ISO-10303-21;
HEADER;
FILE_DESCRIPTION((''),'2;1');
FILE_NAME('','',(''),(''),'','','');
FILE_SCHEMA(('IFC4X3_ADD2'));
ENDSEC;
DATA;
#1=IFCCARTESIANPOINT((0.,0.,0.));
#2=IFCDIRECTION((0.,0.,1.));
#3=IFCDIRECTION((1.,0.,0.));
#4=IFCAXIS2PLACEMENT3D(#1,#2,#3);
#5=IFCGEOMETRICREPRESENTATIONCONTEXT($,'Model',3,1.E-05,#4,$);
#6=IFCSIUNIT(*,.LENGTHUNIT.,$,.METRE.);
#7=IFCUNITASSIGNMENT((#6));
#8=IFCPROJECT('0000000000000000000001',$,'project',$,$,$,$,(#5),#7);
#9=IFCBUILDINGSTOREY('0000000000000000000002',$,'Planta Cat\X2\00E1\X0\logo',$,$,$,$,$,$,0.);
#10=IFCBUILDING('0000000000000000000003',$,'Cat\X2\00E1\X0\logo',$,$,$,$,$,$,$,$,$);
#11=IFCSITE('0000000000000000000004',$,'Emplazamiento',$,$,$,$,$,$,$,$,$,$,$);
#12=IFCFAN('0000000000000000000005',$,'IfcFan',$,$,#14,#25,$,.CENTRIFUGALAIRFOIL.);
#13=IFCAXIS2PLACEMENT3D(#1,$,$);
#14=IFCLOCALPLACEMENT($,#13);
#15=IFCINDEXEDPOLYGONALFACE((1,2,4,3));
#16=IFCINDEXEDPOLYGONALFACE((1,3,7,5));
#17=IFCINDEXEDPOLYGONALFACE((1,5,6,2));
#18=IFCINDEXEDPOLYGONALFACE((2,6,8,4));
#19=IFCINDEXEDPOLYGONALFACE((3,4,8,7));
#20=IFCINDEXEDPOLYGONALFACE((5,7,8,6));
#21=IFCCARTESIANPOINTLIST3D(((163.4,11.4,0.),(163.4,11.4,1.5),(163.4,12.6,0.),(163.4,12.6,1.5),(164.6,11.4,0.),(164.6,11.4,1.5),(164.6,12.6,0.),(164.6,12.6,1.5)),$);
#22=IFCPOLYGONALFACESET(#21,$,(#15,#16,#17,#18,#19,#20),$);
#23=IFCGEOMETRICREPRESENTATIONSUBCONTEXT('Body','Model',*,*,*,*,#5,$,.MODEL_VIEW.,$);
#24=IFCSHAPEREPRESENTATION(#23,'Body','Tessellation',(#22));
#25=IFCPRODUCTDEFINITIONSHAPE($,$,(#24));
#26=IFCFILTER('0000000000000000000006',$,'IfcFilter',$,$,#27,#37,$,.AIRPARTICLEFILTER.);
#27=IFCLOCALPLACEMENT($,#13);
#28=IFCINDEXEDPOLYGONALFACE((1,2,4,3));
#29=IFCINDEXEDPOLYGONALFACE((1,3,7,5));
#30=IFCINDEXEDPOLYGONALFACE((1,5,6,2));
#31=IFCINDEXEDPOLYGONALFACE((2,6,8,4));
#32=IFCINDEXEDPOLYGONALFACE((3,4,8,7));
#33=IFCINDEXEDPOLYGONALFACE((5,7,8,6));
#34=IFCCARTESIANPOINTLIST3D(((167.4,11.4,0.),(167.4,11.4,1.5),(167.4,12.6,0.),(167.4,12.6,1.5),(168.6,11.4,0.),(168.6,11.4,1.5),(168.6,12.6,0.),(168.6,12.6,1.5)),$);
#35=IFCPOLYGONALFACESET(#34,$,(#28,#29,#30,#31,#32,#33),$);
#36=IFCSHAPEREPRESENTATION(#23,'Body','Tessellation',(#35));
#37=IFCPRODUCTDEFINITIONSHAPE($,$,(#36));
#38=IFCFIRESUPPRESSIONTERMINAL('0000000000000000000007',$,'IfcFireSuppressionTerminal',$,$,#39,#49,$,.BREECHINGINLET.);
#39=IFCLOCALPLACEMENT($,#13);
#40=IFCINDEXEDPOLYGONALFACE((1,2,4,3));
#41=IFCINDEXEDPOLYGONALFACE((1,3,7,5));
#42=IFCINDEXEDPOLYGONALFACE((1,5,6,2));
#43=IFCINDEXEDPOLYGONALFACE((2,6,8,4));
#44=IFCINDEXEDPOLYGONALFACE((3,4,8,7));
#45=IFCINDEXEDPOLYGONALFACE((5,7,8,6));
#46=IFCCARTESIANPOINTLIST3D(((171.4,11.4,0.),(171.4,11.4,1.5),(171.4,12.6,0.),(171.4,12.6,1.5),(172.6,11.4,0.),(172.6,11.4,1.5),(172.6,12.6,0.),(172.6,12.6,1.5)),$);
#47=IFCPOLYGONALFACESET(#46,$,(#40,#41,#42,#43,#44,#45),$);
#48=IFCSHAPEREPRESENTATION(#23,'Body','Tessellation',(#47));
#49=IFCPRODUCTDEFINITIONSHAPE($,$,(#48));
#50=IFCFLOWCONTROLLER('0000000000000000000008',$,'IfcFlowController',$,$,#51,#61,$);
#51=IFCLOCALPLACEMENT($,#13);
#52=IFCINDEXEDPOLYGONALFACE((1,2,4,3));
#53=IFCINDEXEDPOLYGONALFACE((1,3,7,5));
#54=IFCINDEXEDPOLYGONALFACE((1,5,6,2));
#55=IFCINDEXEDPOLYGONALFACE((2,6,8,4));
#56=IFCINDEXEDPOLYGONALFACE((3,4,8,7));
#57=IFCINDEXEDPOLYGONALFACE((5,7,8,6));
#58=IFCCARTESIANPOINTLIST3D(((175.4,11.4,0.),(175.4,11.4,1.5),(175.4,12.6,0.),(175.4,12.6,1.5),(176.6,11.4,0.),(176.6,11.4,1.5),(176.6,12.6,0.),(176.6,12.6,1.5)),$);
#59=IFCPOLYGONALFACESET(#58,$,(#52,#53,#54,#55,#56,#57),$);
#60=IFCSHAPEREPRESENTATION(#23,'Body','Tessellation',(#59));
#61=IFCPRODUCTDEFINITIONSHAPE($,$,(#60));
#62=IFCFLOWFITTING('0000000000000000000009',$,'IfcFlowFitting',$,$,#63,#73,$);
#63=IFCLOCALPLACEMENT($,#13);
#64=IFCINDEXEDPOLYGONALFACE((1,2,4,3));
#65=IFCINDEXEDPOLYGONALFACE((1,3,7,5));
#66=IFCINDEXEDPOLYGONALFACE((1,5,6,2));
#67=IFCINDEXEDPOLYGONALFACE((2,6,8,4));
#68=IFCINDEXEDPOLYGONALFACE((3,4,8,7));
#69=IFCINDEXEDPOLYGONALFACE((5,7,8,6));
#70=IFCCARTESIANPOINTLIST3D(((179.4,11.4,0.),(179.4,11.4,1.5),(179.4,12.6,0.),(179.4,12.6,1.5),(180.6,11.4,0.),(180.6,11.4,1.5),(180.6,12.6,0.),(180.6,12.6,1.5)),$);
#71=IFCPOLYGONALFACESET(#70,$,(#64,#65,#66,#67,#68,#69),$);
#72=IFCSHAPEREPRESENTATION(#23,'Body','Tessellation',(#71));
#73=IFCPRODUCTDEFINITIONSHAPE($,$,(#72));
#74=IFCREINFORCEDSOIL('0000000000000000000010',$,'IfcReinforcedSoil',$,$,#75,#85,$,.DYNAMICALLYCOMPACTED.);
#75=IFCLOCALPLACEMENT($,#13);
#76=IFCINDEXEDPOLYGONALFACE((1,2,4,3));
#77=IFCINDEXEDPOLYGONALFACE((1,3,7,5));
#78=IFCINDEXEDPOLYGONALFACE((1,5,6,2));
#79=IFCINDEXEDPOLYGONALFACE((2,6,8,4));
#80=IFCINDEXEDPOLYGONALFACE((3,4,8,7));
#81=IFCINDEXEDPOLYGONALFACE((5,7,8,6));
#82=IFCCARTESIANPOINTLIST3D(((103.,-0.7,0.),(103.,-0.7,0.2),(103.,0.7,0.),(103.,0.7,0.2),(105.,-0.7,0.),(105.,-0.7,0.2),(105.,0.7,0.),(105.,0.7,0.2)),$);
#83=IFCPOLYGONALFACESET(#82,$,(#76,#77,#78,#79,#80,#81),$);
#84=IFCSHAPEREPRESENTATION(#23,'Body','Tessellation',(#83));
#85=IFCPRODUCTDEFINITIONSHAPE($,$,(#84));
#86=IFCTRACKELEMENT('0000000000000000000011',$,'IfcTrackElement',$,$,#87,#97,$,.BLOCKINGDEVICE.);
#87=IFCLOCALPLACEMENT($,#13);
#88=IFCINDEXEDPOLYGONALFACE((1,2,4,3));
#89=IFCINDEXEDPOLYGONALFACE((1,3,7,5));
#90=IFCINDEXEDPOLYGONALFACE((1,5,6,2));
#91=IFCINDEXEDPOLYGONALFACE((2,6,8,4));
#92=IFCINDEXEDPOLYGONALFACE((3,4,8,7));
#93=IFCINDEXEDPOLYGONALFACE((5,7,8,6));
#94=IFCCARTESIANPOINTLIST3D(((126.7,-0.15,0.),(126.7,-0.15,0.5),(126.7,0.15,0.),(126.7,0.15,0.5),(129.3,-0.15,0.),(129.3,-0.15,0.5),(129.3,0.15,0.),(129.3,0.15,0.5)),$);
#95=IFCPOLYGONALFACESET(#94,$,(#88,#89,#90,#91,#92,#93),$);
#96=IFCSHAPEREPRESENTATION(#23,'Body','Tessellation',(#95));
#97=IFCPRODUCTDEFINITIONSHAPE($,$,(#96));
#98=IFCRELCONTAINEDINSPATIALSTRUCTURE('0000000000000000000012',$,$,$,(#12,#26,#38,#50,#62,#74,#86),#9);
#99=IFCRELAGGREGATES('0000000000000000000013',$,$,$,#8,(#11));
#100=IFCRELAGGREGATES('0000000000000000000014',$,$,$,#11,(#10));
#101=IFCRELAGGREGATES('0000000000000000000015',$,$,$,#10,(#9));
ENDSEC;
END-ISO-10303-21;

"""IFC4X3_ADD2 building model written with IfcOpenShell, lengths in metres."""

from ifc_helpers import new_model, si_unit, frame, origin, origin_with_axes, origin_2d, place, context, subcontext, project, spatial, rectangle, extrude, element, save


model = new_model("IFC4X3_ADD2")

# Units and contexts
model_context = context("Model", 3, precision=1e-05, world=origin_with_axes())
body_context = subcontext(model_context, "Body", "Model", "MODEL_VIEW")
ifc_project = project(units=[si_unit("LENGTHUNIT", "METRE")], contexts=[model_context])

# Site, building, storey
site = spatial("IfcSite", under=ifc_project, Name="Emplazamiento")
building = spatial("IfcBuilding", under=site, Name="Catálogo")
storey = spatial("IfcBuildingStorey", under=building, Name="Planta Catálogo", Elevation=0.0)

# Fan
fan_placement = place(None, frame((164.0, 12.0, 0.0), z_axis=(0.0, 0.0, 1.0), x_axis=(1.0, 0.0, 0.0)))
element("IfcFan", 1, at=fan_placement, inside=storey, Name="IfcFan", PredefinedType="CENTRIFUGALAIRFOIL", context=body_context, shape_type="SweptSolid", body=[
    extrude(rectangle(XDim=1.2, YDim=1.2, at=origin_2d()), origin(), (0.0, 0.0, 1.0), 1.5),
])

# Filter
ifc_filter_placement = place(None, frame((168.0, 12.0, 0.0), z_axis=(0.0, 0.0, 1.0), x_axis=(1.0, 0.0, 0.0)))
element("IfcFilter", 2, at=ifc_filter_placement, inside=storey, Name="IfcFilter", PredefinedType="AIRPARTICLEFILTER", context=body_context, shape_type="SweptSolid", body=[
    extrude(rectangle(XDim=1.2, YDim=1.2, at=origin_2d()), origin(), (0.0, 0.0, 1.0), 1.5),
])

# Fire suppression terminal
fire_suppression_terminal_placement = place(None, frame((172.0, 12.0, 0.0), z_axis=(0.0, 0.0, 1.0), x_axis=(1.0, 0.0, 0.0)))
element("IfcFireSuppressionTerminal", 3, at=fire_suppression_terminal_placement, inside=storey, Name="IfcFireSuppressionTerminal", PredefinedType="BREECHINGINLET", context=body_context, shape_type="SweptSolid", body=[
    extrude(rectangle(XDim=1.2, YDim=1.2, at=origin_2d()), origin(), (0.0, 0.0, 1.0), 1.5),
])

# Flow controller
flow_controller_placement = place(None, frame((176.0, 12.0, 0.0), z_axis=(0.0, 0.0, 1.0), x_axis=(1.0, 0.0, 0.0)))
element("IfcFlowController", 4, at=flow_controller_placement, inside=storey, Name="IfcFlowController", context=body_context, shape_type="SweptSolid", body=[
    extrude(rectangle(XDim=1.2, YDim=1.2, at=origin_2d()), origin(), (0.0, 0.0, 1.0), 1.5),
])

# Flow fitting
flow_fitting_placement = place(None, frame((180.0, 12.0, 0.0), z_axis=(0.0, 0.0, 1.0), x_axis=(1.0, 0.0, 0.0)))
element("IfcFlowFitting", 5, at=flow_fitting_placement, inside=storey, Name="IfcFlowFitting", context=body_context, shape_type="SweptSolid", body=[
    extrude(rectangle(XDim=1.2, YDim=1.2, at=origin_2d()), origin(), (0.0, 0.0, 1.0), 1.5),
])

# Reinforced soil
reinforced_soil_placement = place(None, frame((104.0, 0.0, 0.0), z_axis=(0.0, 0.0, 1.0), x_axis=(1.0, 0.0, 0.0)))
element("IfcReinforcedSoil", 6, at=reinforced_soil_placement, inside=storey, Name="IfcReinforcedSoil", PredefinedType="DYNAMICALLYCOMPACTED", context=body_context, shape_type="SweptSolid", body=[
    extrude(rectangle(XDim=2.0, YDim=1.4, at=origin_2d()), origin(), (0.0, 0.0, 1.0), 0.2),
])

# Track element
track_element_placement = place(None, frame((128.0, 0.0, 0.0), z_axis=(0.0, 0.0, 1.0), x_axis=(1.0, 0.0, 0.0)))
element("IfcTrackElement", 7, at=track_element_placement, inside=storey, Name="IfcTrackElement", PredefinedType="BLOCKINGDEVICE", context=body_context, shape_type="SweptSolid", body=[
    extrude(rectangle(XDim=2.6, YDim=0.3, at=origin_2d()), origin(), (0.0, 0.0, 1.0), 0.5),
])

save(model, "model.ifc")
